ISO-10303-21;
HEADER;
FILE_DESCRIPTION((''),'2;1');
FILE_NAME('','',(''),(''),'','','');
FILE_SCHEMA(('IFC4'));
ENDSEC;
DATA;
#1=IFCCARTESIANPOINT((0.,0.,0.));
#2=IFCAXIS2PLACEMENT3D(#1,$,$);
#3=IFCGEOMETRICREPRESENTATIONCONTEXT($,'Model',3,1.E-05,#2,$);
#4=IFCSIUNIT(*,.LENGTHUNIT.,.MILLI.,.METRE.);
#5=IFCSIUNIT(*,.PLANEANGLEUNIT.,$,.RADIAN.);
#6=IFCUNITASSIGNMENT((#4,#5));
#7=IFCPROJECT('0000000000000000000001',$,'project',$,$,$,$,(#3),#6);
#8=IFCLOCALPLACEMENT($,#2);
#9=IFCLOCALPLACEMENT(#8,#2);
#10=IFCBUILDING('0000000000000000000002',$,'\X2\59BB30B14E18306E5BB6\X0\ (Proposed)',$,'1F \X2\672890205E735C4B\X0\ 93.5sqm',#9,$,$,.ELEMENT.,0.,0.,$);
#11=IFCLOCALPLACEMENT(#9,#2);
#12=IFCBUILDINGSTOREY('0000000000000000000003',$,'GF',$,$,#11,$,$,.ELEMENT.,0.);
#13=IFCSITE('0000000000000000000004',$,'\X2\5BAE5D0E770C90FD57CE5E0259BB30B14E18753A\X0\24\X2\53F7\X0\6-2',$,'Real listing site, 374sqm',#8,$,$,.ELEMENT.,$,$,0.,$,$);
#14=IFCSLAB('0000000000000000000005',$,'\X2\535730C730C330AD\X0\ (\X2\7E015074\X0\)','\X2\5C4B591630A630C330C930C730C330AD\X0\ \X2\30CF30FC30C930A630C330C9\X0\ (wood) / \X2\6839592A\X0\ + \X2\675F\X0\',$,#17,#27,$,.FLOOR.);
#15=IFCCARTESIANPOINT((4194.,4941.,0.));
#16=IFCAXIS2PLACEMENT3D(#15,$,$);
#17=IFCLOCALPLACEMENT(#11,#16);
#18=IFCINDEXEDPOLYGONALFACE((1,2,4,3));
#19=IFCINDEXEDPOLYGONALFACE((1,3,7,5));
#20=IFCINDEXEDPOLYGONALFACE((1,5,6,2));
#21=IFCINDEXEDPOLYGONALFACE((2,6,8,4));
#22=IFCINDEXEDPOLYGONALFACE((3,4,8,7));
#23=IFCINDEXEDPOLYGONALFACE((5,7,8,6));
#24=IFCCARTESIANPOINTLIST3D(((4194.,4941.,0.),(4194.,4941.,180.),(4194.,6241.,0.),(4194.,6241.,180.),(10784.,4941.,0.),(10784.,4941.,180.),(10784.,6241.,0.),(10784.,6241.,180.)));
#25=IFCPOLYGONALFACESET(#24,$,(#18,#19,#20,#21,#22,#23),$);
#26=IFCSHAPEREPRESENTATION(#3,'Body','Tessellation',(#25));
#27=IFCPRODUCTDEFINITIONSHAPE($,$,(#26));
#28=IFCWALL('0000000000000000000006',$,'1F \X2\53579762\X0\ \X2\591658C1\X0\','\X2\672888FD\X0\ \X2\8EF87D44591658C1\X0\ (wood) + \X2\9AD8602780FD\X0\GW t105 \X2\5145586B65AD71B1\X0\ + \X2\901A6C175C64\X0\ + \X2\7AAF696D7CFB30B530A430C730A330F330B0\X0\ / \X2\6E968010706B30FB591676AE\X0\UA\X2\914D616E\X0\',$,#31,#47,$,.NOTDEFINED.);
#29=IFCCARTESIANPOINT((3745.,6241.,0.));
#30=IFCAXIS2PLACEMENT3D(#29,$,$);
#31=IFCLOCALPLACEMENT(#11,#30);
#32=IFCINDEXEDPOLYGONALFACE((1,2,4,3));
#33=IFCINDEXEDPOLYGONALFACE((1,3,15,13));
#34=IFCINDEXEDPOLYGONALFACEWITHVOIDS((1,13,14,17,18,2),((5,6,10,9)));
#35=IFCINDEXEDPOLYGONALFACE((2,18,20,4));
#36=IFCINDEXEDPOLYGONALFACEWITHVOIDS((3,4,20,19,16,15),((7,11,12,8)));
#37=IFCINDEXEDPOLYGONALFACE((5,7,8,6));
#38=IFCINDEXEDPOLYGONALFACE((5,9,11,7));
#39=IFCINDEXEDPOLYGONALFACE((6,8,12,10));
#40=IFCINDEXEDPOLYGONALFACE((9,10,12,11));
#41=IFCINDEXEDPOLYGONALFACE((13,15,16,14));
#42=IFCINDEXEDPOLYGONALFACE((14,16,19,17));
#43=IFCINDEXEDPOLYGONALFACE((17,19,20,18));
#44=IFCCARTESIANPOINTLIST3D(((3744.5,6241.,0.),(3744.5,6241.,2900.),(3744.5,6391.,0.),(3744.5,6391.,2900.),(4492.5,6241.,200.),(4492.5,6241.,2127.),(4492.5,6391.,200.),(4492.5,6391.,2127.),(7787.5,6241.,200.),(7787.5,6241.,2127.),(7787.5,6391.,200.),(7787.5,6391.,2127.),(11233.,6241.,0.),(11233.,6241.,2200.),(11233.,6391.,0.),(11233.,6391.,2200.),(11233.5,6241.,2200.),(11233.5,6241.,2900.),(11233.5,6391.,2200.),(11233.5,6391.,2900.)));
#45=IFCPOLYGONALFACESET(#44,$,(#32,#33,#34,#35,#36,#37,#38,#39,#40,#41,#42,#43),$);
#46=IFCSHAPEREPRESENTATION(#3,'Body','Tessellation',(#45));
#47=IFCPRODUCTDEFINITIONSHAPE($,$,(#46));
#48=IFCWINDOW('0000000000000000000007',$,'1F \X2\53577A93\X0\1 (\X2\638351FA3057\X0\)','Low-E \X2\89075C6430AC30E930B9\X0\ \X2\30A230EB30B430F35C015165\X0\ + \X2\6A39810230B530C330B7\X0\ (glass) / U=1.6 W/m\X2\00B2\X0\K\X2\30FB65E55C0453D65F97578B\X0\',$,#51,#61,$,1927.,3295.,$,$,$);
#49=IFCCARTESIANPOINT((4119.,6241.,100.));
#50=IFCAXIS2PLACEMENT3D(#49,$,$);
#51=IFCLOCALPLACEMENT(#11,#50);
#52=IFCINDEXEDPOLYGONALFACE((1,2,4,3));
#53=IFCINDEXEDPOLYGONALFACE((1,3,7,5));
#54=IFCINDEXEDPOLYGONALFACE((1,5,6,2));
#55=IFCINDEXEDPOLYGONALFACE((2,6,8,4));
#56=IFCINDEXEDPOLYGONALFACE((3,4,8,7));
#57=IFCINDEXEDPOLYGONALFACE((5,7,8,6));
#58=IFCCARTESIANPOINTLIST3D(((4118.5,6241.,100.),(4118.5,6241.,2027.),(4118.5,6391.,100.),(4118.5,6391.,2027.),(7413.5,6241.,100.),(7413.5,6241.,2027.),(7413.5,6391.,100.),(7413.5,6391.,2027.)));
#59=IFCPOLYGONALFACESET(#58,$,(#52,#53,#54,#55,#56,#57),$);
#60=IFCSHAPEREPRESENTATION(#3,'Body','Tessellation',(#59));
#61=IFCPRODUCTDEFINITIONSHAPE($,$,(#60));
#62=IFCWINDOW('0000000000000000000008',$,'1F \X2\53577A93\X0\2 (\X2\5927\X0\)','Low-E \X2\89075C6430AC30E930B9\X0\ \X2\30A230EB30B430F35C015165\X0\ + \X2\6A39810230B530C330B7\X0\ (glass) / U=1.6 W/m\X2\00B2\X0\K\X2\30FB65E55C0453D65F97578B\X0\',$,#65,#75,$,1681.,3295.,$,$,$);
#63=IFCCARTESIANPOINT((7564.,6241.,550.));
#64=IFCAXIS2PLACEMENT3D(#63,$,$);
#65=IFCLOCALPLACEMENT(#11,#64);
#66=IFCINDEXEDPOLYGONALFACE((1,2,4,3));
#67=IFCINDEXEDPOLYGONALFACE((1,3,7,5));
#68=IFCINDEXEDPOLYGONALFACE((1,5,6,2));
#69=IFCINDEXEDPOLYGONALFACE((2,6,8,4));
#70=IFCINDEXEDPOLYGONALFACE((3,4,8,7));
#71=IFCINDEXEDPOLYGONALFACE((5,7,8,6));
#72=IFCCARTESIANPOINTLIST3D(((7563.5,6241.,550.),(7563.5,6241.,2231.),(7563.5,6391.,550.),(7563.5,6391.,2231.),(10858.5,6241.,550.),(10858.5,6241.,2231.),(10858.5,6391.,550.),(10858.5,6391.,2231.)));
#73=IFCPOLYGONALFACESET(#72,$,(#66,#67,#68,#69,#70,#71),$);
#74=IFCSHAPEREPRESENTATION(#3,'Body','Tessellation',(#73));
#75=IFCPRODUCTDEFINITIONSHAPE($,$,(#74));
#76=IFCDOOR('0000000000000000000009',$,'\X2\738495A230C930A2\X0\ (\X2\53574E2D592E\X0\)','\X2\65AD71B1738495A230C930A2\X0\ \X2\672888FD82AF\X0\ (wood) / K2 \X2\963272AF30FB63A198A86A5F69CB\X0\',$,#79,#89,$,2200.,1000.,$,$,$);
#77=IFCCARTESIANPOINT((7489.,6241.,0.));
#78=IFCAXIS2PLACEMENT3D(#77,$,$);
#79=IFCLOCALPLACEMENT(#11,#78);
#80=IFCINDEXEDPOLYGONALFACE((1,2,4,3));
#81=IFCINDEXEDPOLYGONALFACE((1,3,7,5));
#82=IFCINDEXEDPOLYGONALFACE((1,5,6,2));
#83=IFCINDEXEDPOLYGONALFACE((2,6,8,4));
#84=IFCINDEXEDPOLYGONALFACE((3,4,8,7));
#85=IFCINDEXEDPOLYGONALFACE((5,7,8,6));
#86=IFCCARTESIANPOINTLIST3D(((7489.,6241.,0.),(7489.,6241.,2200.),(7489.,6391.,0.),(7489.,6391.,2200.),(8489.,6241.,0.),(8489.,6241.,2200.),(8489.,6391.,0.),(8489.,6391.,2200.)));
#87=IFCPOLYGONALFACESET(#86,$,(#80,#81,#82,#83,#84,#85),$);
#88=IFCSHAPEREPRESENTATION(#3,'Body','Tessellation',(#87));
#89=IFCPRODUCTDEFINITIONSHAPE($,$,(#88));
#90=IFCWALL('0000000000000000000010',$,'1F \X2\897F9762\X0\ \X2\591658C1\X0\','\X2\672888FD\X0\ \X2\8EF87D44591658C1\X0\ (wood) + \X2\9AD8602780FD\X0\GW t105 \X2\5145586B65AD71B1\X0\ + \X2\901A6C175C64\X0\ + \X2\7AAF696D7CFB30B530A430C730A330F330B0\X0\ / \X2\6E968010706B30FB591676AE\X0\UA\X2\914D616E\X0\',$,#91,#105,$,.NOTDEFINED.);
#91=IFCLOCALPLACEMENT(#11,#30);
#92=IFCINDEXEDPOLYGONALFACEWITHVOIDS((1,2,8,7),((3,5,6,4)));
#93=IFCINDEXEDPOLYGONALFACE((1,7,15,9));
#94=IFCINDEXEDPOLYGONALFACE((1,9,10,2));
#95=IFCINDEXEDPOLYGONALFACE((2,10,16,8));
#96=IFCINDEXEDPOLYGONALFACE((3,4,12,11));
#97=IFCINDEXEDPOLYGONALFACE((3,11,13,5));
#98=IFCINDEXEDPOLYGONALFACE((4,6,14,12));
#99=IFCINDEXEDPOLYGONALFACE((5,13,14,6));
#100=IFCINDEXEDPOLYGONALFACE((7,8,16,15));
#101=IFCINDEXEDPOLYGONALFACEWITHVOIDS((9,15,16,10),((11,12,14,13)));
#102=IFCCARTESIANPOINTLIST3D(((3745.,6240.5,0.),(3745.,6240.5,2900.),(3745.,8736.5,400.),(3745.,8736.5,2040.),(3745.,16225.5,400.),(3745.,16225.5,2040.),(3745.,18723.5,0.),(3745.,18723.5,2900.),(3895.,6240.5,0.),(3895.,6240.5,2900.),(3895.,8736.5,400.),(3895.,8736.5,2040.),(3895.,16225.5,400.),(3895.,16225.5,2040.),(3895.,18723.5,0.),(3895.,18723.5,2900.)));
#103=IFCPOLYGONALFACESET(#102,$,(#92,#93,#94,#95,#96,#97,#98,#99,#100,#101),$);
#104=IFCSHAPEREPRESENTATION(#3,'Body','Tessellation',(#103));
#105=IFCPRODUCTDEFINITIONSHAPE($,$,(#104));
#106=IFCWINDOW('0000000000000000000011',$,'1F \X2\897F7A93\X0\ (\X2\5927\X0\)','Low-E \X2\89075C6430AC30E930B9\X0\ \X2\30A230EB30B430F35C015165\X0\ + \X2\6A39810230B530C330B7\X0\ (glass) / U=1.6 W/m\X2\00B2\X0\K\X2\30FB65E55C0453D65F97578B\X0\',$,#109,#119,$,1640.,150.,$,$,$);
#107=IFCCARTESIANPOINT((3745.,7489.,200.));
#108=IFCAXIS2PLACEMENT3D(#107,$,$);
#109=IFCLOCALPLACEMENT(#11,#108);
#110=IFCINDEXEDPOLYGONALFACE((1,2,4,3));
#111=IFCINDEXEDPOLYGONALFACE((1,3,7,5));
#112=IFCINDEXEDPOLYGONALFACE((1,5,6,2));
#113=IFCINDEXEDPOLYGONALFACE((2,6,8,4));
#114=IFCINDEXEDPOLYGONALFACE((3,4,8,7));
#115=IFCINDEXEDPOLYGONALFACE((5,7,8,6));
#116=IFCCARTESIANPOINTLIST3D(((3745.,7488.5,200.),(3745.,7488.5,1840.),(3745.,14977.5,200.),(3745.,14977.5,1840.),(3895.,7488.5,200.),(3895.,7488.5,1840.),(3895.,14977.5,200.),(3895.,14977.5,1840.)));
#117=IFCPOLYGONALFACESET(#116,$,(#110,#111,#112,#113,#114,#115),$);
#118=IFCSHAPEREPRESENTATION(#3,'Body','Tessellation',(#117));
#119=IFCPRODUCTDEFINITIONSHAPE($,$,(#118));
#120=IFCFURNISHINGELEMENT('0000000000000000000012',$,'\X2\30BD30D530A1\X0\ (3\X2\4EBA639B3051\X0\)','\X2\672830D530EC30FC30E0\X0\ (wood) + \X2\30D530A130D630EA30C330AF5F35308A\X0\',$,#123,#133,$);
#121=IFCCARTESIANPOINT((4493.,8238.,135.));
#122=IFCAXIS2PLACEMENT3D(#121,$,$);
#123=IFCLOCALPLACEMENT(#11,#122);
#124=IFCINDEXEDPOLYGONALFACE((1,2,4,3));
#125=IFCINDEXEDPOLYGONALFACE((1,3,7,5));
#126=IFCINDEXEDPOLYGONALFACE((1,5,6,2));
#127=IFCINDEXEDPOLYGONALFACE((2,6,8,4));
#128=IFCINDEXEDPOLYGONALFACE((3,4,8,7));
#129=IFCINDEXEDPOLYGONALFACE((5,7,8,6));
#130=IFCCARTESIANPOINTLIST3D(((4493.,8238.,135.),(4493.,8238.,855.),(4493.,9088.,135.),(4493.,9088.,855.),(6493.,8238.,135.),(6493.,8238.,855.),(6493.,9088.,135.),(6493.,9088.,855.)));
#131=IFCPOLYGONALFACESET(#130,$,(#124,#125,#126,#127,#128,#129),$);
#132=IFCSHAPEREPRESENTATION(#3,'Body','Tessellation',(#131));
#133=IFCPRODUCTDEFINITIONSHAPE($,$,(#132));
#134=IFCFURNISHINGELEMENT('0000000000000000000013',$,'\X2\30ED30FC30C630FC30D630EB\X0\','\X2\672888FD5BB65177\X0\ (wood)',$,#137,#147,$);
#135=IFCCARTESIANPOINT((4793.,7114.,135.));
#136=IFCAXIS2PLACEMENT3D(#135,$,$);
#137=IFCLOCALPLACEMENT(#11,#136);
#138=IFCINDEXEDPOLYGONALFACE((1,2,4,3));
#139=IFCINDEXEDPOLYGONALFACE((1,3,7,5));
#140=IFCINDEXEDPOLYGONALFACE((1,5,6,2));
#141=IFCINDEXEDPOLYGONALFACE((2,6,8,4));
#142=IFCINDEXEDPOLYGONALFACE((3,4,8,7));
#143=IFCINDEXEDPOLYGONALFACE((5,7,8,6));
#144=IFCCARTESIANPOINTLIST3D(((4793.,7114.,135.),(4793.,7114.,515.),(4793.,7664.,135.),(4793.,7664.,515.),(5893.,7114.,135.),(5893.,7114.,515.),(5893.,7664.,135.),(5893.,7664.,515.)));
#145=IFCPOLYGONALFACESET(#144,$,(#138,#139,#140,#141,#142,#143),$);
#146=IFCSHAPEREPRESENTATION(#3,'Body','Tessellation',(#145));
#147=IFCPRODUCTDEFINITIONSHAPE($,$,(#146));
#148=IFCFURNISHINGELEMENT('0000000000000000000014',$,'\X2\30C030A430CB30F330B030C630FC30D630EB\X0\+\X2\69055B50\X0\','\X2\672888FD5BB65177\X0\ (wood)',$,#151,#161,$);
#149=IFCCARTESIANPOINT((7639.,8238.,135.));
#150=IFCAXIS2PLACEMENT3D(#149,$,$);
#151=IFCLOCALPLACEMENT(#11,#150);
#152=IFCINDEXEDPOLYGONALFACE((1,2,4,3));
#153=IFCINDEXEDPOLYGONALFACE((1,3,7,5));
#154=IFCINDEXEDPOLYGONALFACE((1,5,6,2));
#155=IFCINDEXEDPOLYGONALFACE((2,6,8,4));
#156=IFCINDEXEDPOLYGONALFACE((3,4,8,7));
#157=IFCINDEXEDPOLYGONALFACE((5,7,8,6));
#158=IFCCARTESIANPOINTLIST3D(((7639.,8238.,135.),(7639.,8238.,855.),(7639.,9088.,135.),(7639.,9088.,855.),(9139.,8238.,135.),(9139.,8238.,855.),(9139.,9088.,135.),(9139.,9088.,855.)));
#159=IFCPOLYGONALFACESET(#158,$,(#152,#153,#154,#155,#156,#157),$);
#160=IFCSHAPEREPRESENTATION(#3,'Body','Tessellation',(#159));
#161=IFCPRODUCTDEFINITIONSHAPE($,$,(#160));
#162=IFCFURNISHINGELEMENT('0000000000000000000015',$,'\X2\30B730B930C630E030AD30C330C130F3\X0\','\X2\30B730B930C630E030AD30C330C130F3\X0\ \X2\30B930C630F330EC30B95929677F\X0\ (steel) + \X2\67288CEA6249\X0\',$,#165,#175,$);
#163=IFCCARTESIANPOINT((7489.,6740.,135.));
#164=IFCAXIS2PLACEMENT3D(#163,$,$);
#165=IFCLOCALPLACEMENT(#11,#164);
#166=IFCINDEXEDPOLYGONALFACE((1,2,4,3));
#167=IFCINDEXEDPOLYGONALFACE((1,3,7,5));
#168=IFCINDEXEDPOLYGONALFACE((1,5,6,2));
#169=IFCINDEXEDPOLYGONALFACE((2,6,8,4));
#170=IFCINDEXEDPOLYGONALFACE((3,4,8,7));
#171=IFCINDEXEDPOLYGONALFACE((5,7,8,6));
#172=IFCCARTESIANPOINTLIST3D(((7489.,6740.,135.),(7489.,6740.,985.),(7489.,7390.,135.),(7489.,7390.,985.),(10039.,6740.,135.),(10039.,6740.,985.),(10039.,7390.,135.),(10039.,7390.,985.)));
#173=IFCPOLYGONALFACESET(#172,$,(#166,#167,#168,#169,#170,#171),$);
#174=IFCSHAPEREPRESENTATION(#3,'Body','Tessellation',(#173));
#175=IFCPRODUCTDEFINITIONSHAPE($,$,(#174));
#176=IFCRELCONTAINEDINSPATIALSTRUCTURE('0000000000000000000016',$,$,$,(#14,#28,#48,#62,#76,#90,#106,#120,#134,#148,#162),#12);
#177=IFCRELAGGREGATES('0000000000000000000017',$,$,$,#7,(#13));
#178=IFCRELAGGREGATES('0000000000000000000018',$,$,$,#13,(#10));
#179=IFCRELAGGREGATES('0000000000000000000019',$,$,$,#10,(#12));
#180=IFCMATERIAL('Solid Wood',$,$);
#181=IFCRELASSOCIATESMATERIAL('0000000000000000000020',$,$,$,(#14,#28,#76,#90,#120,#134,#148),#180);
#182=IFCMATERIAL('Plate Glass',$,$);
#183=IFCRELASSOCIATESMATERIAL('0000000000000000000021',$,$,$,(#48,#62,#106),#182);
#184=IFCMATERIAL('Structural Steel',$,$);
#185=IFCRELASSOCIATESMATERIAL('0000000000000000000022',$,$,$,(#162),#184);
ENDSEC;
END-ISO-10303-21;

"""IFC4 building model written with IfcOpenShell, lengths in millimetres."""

from ifc_helpers import new_model, si_unit, frame, frame_2d, origin, place, context, project, spatial, rectangle, extrude, material, element, fill, save


model = new_model("IFC4")

# Units and contexts
model_context = context("Model", 3, precision=1e-05, world=origin())
ifc_project = project(units=[si_unit("LENGTHUNIT", "METRE", prefix="MILLI"), si_unit("PLANEANGLEUNIT", "RADIAN")], contexts=[model_context])

# Site, building, storey
site_placement = place(None, origin())
site = spatial("IfcSite", under=ifc_project, at=site_placement, Name="宮崎県都城市妻ケ丘町24号6-2", ObjectType="Real listing site, 374sqm", CompositionType="ELEMENT", RefElevation=0.0)
building_placement = place(site_placement, origin())
building = spatial("IfcBuilding", under=site, at=building_placement, Name="妻ケ丘の家 (Proposed)", ObjectType="1F 木造平屋 93.5sqm", CompositionType="ELEMENT", ElevationOfRefHeight=0.0, ElevationOfTerrain=0.0)
storey_placement = place(building_placement, origin())
storey = spatial("IfcBuildingStorey", under=building, at=storey_placement, Name="GF", CompositionType="ELEMENT", Elevation=0.0)

# Slab
ifc_material_1 = material(Name="Solid Wood")
slab_1_placement = place(storey_placement, frame((4194.0, 4941.0, 0.0)))
element("IfcSlab", 1, at=slab_1_placement, inside=storey, material=ifc_material_1, Name="南デッキ (縁側)", Description="屋外ウッドデッキ ハードウッド (wood) / 根太 + 束", PredefinedType="FLOOR", context=model_context, shape_type="SweptSolid", body=[
    extrude(rectangle(XDim=6590.0, YDim=1300.0, at=frame_2d((3295.0, 650.0))), frame((4194.0, 4941.0, 0.0)), (0.0, 0.0, 1.0), 180.0),
])

# Wall, openings, windows, door
wall_1_placement = place(storey_placement, frame((3745.0, 6241.0, 0.0)))
wall_1 = element("IfcWall", 2, at=wall_1_placement, inside=storey, material=ifc_material_1, Name="1F 南面 外壁", Description="木製 軸組外壁 (wood) + 高性能GW t105 充填断熱 + 通気層 + 窯業系サイディング / 準耐火・外皮UA配慮", PredefinedType="NOTDEFINED", context=model_context, shape_type="SweptSolid", body=[
    extrude(rectangle(XDim=7489.0, YDim=150.0, at=frame_2d((3744.0, 75.0))), frame((3745.0, 6241.0, 0.0)), (0.0, 0.0, 1.0), 2900.0),
])
opening_1_placement = place(storey_placement, frame((4119.0, 6241.0, 100.0)))
opening_1 = element("IfcOpeningElement", 3, at=opening_1_placement, cuts=wall_1, PredefinedType="NOTDEFINED", context=model_context, shape_type="SweptSolid", body=[
    extrude(rectangle(XDim=3295.0, YDim=150.0, at=frame_2d((1647.0, 75.0))), frame((4119.0, 6241.0, 100.0)), (0.0, 0.0, 1.0), 1927.0),
])
opening_2_placement = place(storey_placement, frame((7564.0, 6241.0, 550.0)))
opening_2 = element("IfcOpeningElement", 4, at=opening_2_placement, cuts=wall_1, PredefinedType="NOTDEFINED", context=model_context, shape_type="SweptSolid", body=[
    extrude(rectangle(XDim=3295.0, YDim=150.0, at=frame_2d((1647.0, 75.0))), frame((7564.0, 6241.0, 550.0)), (0.0, 0.0, 1.0), 1681.0),
])
opening_3_placement = place(storey_placement, frame((7489.0, 6241.0, 0.0)))
opening_3 = element("IfcOpeningElement", 5, at=opening_3_placement, cuts=wall_1, PredefinedType="NOTDEFINED", context=model_context, shape_type="SweptSolid", body=[
    extrude(rectangle(XDim=1000.0, YDim=150.0, at=frame_2d((500.0, 75.0))), frame((7489.0, 6241.0, 0.0)), (0.0, 0.0, 1.0), 2200.0),
])
ifc_material_2 = material(Name="Plate Glass")
window_1_placement = place(storey_placement, frame((4119.0, 6241.0, 100.0)))
window_1 = element("IfcWindow", 6, at=window_1_placement, inside=storey, material=ifc_material_2, Name="1F 南窓1 (掃出し)", Description="Low-E 複層ガラス アルゴン封入 + 樹脂サッシ (glass) / U=1.6 W/m²K・日射取得型", OverallHeight=1927.0, OverallWidth=3295.0, context=model_context, shape_type="SweptSolid", body=[
    extrude(rectangle(XDim=3295.0, YDim=150.0, at=frame_2d((1647.0, 75.0))), frame((4119.0, 6241.0, 100.0)), (0.0, 0.0, 1.0), 1927.0),
])
fill(opening_1, window_1)
window_2_placement = place(storey_placement, frame((7564.0, 6241.0, 550.0)))
window_2 = element("IfcWindow", 7, at=window_2_placement, inside=storey, material=ifc_material_2, Name="1F 南窓2 (大)", Description="Low-E 複層ガラス アルゴン封入 + 樹脂サッシ (glass) / U=1.6 W/m²K・日射取得型", OverallHeight=1681.0, OverallWidth=3295.0, context=model_context, shape_type="SweptSolid", body=[
    extrude(rectangle(XDim=3295.0, YDim=150.0, at=frame_2d((1647.0, 75.0))), frame((7564.0, 6241.0, 550.0)), (0.0, 0.0, 1.0), 1681.0),
])
fill(opening_2, window_2)
door_placement = place(storey_placement, frame((7489.0, 6241.0, 0.0)))
door = element("IfcDoor", 8, at=door_placement, inside=storey, material=ifc_material_1, Name="玄関ドア (南中央)", Description="断熱玄関ドア 木製芯 (wood) / K2 防犯・採風機構", OverallHeight=2200.0, OverallWidth=1000.0, context=model_context, shape_type="SweptSolid", body=[
    extrude(rectangle(XDim=1000.0, YDim=150.0, at=frame_2d((500.0, 75.0))), frame((7489.0, 6241.0, 0.0)), (0.0, 0.0, 1.0), 2200.0),
])
fill(opening_3, door)

# Wall, opening, window
wall_2_placement = place(storey_placement, frame((3745.0, 6241.0, 0.0)))
wall_2 = element("IfcWall", 9, at=wall_2_placement, inside=storey, material=ifc_material_1, Name="1F 西面 外壁", Description="木製 軸組外壁 (wood) + 高性能GW t105 充填断熱 + 通気層 + 窯業系サイディング / 準耐火・外皮UA配慮", PredefinedType="NOTDEFINED", context=model_context, shape_type="SweptSolid", body=[
    extrude(rectangle(XDim=150.0, YDim=12483.0, at=frame_2d((75.0, 6241.0))), frame((3745.0, 6241.0, 0.0)), (0.0, 0.0, 1.0), 2900.0),
])
opening_4_placement = place(storey_placement, frame((3745.0, 7489.0, 200.0)))
opening_4 = element("IfcOpeningElement", 10, at=opening_4_placement, cuts=wall_2, PredefinedType="NOTDEFINED", context=model_context, shape_type="SweptSolid", body=[
    extrude(rectangle(XDim=150.0, YDim=7489.0, at=frame_2d((75.0, 3744.0))), frame((3745.0, 7489.0, 200.0)), (0.0, 0.0, 1.0), 1640.0),
])
window_3_placement = place(storey_placement, frame((3745.0, 7489.0, 200.0)))
window_3 = element("IfcWindow", 11, at=window_3_placement, inside=storey, material=ifc_material_2, Name="1F 西窓 (大)", Description="Low-E 複層ガラス アルゴン封入 + 樹脂サッシ (glass) / U=1.6 W/m²K・日射取得型", OverallHeight=1640.0, OverallWidth=150.0, context=model_context, shape_type="SweptSolid", body=[
    extrude(rectangle(XDim=150.0, YDim=7489.0, at=frame_2d((75.0, 3744.0))), frame((3745.0, 7489.0, 200.0)), (0.0, 0.0, 1.0), 1640.0),
])
fill(opening_4, window_3)

# Shared definitions
ifc_material_3 = material(Name="Structural Steel")

# Furnishing elements
furnishing_1_placement = place(storey_placement, frame((4493.0, 8238.0, 135.0)))
element("IfcFurnishingElement", 12, at=furnishing_1_placement, inside=storey, material=ifc_material_1, Name="ソファ (3人掛け)", Description="木フレーム (wood) + ファブリック張り", context=model_context, shape_type="SweptSolid", body=[
    extrude(rectangle(XDim=2000.0, YDim=850.0, at=frame_2d((1000.0, 425.0))), frame((4493.0, 8238.0, 135.0)), (0.0, 0.0, 1.0), 720.0),
])
furnishing_2_placement = place(storey_placement, frame((4793.0, 7114.0, 135.0)))
element("IfcFurnishingElement", 13, at=furnishing_2_placement, inside=storey, material=ifc_material_1, Name="ローテーブル", Description="木製家具 (wood)", context=model_context, shape_type="SweptSolid", body=[
    extrude(rectangle(XDim=1100.0, YDim=550.0, at=frame_2d((550.0, 275.0))), frame((4793.0, 7114.0, 135.0)), (0.0, 0.0, 1.0), 380.0),
])
furnishing_3_placement = place(storey_placement, frame((7639.0, 8238.0, 135.0)))
element("IfcFurnishingElement", 14, at=furnishing_3_placement, inside=storey, material=ifc_material_1, Name="ダイニングテーブル+椅子", Description="木製家具 (wood)", context=model_context, shape_type="SweptSolid", body=[
    extrude(rectangle(XDim=1500.0, YDim=850.0, at=frame_2d((750.0, 425.0))), frame((7639.0, 8238.0, 135.0)), (0.0, 0.0, 1.0), 720.0),
])
furnishing_4_placement = place(storey_placement, frame((7489.0, 6740.0, 135.0)))
element("IfcFurnishingElement", 15, at=furnishing_4_placement, inside=storey, material=ifc_material_3, Name="システムキッチン", Description="システムキッチン ステンレス天板 (steel) + 木質扉", context=model_context, shape_type="SweptSolid", body=[
    extrude(rectangle(XDim=2550.0, YDim=650.0, at=frame_2d((1275.0, 325.0))), frame((7489.0, 6740.0, 135.0)), (0.0, 0.0, 1.0), 850.0),
])

save(model, "model.ifc")
